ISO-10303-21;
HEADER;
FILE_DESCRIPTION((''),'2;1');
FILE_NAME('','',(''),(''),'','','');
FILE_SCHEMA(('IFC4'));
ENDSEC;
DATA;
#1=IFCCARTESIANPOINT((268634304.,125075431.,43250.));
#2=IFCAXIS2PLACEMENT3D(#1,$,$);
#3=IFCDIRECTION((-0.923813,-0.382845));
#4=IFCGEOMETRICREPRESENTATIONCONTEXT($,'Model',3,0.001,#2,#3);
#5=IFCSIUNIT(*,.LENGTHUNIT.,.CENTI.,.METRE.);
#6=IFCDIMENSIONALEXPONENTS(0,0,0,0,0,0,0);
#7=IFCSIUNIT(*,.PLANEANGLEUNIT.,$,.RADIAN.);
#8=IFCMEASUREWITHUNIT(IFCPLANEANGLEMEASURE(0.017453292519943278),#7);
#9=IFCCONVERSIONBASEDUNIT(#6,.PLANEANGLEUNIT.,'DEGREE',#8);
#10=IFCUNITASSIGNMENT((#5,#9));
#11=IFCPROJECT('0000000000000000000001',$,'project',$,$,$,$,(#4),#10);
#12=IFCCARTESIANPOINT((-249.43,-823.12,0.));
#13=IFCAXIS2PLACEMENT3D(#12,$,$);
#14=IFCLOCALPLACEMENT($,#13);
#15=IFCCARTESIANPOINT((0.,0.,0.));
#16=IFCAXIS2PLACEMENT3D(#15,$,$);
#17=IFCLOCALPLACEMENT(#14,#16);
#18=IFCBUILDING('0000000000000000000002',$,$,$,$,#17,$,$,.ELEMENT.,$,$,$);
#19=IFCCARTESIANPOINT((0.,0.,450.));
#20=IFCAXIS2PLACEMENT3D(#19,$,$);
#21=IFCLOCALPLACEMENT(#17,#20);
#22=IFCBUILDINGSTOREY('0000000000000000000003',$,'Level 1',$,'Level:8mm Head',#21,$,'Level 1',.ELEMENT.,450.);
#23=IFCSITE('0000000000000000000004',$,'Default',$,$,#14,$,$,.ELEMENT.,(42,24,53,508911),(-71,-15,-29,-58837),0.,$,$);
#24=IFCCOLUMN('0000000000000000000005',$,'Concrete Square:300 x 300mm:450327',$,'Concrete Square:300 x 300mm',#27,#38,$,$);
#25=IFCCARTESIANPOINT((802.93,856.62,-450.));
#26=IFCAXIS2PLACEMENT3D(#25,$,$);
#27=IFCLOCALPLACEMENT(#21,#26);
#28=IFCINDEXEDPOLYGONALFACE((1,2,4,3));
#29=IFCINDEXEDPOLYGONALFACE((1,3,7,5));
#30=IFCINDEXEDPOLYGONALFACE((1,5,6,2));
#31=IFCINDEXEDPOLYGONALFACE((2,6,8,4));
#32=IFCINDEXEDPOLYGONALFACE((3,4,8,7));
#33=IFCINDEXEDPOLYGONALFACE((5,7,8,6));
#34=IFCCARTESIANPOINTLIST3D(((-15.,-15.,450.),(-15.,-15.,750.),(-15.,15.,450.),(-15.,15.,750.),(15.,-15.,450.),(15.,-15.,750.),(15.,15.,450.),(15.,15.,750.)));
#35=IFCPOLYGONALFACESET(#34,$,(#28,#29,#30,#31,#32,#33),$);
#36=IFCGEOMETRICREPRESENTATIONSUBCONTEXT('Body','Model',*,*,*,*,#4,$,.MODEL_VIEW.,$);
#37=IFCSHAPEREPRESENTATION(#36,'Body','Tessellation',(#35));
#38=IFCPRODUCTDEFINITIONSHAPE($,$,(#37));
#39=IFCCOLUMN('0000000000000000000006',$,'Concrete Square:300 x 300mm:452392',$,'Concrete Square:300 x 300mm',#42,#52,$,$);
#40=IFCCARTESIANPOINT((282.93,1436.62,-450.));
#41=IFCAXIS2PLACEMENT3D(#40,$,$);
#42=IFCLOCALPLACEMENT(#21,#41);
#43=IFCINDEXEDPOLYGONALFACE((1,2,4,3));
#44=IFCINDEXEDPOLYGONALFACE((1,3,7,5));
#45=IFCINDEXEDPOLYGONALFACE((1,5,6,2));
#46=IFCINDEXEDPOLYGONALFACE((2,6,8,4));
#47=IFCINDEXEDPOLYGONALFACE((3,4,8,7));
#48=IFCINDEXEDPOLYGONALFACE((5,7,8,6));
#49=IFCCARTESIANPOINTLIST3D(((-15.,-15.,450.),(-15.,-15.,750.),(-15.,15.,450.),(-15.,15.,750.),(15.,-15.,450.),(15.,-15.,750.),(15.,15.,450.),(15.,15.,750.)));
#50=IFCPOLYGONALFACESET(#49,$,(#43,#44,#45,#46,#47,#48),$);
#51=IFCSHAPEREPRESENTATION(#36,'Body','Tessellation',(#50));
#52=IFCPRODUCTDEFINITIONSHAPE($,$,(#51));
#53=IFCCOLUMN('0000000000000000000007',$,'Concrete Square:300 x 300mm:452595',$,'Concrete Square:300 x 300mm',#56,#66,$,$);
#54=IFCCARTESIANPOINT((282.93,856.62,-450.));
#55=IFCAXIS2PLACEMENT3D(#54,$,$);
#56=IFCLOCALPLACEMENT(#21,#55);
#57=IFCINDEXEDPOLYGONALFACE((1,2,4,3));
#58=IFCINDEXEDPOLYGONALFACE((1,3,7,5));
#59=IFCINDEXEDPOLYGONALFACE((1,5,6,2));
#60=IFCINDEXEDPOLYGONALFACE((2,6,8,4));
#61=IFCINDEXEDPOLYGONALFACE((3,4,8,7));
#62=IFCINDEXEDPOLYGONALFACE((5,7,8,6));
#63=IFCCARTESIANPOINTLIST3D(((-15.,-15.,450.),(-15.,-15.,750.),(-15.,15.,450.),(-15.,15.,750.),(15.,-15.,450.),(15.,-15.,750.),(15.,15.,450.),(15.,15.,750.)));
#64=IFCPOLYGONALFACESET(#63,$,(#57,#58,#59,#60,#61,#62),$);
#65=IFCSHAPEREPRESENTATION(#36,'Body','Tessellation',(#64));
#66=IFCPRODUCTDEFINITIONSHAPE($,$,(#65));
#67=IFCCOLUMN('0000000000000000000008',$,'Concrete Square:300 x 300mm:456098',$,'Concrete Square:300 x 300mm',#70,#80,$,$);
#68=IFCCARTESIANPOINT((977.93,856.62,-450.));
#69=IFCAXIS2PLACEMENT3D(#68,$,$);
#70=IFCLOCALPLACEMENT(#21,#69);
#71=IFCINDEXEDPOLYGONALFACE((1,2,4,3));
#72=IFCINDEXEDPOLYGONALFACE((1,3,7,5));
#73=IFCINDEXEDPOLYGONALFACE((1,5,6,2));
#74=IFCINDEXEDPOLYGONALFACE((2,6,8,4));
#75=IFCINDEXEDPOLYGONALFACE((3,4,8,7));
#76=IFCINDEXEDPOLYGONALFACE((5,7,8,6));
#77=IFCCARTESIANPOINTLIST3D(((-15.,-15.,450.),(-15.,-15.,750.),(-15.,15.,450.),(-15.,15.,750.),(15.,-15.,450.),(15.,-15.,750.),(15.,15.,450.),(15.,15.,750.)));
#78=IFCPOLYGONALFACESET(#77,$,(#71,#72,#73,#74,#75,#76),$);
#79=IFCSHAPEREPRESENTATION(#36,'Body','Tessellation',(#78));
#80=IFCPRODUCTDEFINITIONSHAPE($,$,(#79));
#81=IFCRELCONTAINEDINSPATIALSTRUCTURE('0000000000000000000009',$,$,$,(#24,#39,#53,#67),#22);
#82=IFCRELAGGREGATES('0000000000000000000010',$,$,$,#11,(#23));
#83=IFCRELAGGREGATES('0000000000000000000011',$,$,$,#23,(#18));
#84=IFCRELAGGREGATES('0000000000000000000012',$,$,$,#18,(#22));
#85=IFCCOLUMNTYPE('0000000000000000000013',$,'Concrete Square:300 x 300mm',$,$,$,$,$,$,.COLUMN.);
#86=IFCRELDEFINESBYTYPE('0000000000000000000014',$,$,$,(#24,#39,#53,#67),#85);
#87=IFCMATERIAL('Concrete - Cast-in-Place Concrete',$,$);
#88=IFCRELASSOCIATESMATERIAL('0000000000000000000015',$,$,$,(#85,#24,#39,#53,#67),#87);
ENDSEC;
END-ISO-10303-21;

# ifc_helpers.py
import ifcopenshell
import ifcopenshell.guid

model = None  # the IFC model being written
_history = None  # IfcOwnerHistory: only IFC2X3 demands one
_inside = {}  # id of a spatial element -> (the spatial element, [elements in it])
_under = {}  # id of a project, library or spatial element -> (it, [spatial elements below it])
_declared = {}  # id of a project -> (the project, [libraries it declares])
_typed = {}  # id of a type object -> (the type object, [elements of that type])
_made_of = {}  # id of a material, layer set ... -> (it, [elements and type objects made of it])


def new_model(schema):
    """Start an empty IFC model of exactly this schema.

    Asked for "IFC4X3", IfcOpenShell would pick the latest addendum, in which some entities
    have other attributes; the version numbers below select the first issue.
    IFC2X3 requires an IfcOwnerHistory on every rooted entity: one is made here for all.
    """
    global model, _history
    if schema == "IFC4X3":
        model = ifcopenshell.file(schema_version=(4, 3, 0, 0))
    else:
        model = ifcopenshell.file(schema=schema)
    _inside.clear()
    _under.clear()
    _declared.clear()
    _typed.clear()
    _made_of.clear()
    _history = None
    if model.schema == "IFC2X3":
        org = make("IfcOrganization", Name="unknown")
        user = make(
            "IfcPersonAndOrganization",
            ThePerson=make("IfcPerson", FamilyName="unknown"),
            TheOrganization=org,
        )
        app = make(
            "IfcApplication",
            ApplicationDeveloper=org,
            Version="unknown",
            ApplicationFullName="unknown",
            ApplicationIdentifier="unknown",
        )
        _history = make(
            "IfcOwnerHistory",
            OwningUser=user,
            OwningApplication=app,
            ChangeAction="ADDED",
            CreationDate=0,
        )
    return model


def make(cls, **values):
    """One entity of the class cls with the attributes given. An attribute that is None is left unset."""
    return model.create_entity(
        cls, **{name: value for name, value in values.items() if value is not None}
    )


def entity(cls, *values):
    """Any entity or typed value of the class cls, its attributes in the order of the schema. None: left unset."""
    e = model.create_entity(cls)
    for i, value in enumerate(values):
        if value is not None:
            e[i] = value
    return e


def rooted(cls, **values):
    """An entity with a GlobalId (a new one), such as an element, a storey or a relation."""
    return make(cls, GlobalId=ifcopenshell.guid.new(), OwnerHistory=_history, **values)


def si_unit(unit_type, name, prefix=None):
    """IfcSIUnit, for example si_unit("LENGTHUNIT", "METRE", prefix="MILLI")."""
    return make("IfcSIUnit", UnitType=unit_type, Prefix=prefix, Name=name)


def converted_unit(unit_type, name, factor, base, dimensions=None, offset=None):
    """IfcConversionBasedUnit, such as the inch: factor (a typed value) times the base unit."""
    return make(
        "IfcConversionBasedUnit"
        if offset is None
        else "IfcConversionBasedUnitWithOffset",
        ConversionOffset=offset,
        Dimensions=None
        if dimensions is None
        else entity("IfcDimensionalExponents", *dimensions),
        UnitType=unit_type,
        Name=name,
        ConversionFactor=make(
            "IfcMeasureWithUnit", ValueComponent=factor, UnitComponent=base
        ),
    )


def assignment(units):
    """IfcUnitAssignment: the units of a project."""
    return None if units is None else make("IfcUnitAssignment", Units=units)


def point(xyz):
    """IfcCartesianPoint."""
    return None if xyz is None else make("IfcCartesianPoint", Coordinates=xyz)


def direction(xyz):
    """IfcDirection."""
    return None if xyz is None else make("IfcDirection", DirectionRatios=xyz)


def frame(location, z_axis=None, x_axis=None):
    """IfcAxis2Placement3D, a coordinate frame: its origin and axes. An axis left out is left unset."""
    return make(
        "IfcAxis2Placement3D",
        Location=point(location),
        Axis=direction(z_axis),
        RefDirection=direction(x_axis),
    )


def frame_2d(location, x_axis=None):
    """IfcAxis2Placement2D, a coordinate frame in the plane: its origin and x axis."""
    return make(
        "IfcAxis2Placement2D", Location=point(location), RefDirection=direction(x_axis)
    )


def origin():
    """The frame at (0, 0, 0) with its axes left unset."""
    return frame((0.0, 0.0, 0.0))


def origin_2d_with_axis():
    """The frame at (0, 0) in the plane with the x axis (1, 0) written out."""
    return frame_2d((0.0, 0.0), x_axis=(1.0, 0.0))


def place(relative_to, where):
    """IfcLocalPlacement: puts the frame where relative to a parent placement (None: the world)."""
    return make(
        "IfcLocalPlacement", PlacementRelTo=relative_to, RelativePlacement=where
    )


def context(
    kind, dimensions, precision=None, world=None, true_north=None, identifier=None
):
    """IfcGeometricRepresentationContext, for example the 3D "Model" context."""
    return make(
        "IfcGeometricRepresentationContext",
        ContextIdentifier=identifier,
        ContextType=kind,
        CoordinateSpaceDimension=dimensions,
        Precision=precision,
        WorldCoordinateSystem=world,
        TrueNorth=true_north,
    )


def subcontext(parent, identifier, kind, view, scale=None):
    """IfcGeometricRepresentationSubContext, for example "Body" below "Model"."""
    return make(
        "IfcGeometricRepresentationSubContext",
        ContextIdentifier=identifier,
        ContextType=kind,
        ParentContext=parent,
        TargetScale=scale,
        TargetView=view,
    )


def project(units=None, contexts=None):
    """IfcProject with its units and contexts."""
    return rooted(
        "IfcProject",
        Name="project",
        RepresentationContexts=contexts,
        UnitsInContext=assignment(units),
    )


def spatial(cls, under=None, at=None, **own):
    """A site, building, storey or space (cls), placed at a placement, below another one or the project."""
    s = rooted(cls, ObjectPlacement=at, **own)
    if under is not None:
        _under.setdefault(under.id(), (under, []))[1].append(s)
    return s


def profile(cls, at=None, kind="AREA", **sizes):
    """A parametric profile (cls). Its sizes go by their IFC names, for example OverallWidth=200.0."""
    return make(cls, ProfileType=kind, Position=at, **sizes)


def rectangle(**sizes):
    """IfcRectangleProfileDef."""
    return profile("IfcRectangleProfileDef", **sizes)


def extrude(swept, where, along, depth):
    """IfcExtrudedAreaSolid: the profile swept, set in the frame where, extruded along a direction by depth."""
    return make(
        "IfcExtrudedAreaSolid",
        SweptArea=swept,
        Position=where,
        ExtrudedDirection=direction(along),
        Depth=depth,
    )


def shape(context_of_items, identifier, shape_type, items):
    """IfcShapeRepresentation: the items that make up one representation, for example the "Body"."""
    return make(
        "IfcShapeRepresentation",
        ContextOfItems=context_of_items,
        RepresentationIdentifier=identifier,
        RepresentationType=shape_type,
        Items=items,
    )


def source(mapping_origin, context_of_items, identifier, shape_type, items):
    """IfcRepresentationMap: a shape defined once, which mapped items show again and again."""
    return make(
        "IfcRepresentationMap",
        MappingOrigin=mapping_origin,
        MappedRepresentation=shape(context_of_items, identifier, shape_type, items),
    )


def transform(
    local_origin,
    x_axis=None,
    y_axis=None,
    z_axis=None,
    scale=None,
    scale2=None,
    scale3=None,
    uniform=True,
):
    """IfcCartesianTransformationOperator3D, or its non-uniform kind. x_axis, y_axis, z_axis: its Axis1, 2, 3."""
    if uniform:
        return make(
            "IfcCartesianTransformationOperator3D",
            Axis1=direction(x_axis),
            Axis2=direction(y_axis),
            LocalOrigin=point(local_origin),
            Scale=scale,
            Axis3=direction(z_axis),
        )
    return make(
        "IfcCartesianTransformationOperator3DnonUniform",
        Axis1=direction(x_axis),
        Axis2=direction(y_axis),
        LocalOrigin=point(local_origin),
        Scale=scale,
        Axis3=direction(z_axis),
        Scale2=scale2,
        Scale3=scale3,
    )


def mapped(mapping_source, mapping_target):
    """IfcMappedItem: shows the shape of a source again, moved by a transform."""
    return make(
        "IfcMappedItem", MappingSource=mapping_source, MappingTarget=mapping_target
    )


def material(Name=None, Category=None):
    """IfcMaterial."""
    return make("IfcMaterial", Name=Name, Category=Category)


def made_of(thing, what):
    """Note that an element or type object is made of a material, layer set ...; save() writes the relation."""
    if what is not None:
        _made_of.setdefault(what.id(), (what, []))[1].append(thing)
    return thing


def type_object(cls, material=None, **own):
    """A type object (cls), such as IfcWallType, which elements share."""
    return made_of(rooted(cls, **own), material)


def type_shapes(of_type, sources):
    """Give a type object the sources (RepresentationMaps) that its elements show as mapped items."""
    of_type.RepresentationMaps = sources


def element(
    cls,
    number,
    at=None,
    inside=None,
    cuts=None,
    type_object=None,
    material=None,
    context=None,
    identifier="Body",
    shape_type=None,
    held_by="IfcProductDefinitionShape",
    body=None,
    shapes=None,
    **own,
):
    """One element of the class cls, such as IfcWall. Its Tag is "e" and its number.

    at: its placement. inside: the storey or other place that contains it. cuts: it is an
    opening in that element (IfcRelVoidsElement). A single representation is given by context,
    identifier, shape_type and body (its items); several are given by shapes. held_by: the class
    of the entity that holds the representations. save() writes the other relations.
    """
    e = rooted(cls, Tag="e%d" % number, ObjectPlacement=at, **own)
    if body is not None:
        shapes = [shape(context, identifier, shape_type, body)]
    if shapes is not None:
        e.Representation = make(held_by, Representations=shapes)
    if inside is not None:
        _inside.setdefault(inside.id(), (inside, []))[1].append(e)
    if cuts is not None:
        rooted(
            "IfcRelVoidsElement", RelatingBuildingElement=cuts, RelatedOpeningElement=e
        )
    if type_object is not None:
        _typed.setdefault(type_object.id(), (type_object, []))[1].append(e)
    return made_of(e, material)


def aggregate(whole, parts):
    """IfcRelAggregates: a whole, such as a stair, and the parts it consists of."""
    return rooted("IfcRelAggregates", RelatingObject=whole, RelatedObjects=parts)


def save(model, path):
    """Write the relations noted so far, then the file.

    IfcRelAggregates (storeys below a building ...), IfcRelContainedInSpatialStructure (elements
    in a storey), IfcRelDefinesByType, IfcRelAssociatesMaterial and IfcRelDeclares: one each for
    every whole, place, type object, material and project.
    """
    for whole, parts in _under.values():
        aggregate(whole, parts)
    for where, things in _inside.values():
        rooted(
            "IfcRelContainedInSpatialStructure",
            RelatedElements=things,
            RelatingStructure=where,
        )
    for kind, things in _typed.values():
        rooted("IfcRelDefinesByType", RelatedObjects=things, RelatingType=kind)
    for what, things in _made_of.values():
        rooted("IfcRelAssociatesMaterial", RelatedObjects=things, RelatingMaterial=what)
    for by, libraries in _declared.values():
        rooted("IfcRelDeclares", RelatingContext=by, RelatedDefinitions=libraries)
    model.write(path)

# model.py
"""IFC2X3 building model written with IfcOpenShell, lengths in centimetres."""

from ifc_helpers import new_model, entity, si_unit, converted_unit, direction, frame, origin, origin_2d_with_axis, place, context, subcontext, project, spatial, rectangle, extrude, source, transform, mapped, material, type_object, type_shapes, element, save


model = new_model("IFC2X3")

# Units and contexts
model_context = context("Model", 3, precision=0.001, world=frame((268634304.0, 125075431.0, 43250.0)), true_north=direction((-0.923813, -0.382845)))
body_context = subcontext(model_context, "Body", "Model", "MODEL_VIEW")
ifc_project = project(units=[si_unit("LENGTHUNIT", "METRE", prefix="CENTI"), converted_unit("PLANEANGLEUNIT", "DEGREE", entity("IfcPlaneAngleMeasure", 0.017453292519943278), si_unit("PLANEANGLEUNIT", "RADIAN"), dimensions=[0, 0, 0, 0, 0, 0, 0])], contexts=[model_context])

# Site, building, storey
site_placement = place(None, frame((-249.43, -823.12, 0.0)))
site = spatial("IfcSite", under=ifc_project, at=site_placement, Name="Default", CompositionType="ELEMENT", RefLatitude=(42, 24, 53, 508911), RefLongitude=(-71, -15, -29, -58837), RefElevation=0.0)
building_placement = place(site_placement, origin())
building = spatial("IfcBuilding", under=site, at=building_placement, CompositionType="ELEMENT")
storey_placement = place(building_placement, frame((0.0, 0.0, 450.0)))
storey = spatial("IfcBuildingStorey", under=building, at=storey_placement, Name="Level 1", ObjectType="Level:8mm Head", LongName="Level 1", CompositionType="ELEMENT", Elevation=450.0)

# Columns
ifc_material_1 = material(Name="Concrete - Cast-in-Place Concrete")
column_type = type_object("IfcColumnType", Name="Concrete Square:300 x 300mm", PredefinedType="COLUMN", material=ifc_material_1)
shared_shape_1 = source(origin(), body_context, "Body", "SweptSolid", [
    extrude(rectangle(XDim=30.0, YDim=30.0, at=origin_2d_with_axis()), frame((0.0, 0.0, 450.0), z_axis=(0.0, 0.0, 1.0), x_axis=(-1.0, 0.0, 0.0)), (0.0, 0.0, 1.0), 300.0),
])
type_shapes(column_type, [shared_shape_1])
for number, where, name in (
    (1, (802.93, 856.62, -450.0), "Concrete Square:300 x 300mm:450327"),
    (2, (282.93, 1436.62, -450.0), "Concrete Square:300 x 300mm:452392"),
    (3, (282.93, 856.62, -450.0), "Concrete Square:300 x 300mm:452595"),
    (4, (977.93, 856.62, -450.0), "Concrete Square:300 x 300mm:456098"),
):
    element("IfcColumn", number, at=place(storey_placement, frame(where)), inside=storey, type_object=column_type, material=ifc_material_1, Name=name, ObjectType="Concrete Square:300 x 300mm", context=body_context, shape_type="MappedRepresentation", body=[
        mapped(shared_shape_1, transform((0.0, 0.0, 0.0), scale=1.0)),
    ])

save(model, "model.ifc")
